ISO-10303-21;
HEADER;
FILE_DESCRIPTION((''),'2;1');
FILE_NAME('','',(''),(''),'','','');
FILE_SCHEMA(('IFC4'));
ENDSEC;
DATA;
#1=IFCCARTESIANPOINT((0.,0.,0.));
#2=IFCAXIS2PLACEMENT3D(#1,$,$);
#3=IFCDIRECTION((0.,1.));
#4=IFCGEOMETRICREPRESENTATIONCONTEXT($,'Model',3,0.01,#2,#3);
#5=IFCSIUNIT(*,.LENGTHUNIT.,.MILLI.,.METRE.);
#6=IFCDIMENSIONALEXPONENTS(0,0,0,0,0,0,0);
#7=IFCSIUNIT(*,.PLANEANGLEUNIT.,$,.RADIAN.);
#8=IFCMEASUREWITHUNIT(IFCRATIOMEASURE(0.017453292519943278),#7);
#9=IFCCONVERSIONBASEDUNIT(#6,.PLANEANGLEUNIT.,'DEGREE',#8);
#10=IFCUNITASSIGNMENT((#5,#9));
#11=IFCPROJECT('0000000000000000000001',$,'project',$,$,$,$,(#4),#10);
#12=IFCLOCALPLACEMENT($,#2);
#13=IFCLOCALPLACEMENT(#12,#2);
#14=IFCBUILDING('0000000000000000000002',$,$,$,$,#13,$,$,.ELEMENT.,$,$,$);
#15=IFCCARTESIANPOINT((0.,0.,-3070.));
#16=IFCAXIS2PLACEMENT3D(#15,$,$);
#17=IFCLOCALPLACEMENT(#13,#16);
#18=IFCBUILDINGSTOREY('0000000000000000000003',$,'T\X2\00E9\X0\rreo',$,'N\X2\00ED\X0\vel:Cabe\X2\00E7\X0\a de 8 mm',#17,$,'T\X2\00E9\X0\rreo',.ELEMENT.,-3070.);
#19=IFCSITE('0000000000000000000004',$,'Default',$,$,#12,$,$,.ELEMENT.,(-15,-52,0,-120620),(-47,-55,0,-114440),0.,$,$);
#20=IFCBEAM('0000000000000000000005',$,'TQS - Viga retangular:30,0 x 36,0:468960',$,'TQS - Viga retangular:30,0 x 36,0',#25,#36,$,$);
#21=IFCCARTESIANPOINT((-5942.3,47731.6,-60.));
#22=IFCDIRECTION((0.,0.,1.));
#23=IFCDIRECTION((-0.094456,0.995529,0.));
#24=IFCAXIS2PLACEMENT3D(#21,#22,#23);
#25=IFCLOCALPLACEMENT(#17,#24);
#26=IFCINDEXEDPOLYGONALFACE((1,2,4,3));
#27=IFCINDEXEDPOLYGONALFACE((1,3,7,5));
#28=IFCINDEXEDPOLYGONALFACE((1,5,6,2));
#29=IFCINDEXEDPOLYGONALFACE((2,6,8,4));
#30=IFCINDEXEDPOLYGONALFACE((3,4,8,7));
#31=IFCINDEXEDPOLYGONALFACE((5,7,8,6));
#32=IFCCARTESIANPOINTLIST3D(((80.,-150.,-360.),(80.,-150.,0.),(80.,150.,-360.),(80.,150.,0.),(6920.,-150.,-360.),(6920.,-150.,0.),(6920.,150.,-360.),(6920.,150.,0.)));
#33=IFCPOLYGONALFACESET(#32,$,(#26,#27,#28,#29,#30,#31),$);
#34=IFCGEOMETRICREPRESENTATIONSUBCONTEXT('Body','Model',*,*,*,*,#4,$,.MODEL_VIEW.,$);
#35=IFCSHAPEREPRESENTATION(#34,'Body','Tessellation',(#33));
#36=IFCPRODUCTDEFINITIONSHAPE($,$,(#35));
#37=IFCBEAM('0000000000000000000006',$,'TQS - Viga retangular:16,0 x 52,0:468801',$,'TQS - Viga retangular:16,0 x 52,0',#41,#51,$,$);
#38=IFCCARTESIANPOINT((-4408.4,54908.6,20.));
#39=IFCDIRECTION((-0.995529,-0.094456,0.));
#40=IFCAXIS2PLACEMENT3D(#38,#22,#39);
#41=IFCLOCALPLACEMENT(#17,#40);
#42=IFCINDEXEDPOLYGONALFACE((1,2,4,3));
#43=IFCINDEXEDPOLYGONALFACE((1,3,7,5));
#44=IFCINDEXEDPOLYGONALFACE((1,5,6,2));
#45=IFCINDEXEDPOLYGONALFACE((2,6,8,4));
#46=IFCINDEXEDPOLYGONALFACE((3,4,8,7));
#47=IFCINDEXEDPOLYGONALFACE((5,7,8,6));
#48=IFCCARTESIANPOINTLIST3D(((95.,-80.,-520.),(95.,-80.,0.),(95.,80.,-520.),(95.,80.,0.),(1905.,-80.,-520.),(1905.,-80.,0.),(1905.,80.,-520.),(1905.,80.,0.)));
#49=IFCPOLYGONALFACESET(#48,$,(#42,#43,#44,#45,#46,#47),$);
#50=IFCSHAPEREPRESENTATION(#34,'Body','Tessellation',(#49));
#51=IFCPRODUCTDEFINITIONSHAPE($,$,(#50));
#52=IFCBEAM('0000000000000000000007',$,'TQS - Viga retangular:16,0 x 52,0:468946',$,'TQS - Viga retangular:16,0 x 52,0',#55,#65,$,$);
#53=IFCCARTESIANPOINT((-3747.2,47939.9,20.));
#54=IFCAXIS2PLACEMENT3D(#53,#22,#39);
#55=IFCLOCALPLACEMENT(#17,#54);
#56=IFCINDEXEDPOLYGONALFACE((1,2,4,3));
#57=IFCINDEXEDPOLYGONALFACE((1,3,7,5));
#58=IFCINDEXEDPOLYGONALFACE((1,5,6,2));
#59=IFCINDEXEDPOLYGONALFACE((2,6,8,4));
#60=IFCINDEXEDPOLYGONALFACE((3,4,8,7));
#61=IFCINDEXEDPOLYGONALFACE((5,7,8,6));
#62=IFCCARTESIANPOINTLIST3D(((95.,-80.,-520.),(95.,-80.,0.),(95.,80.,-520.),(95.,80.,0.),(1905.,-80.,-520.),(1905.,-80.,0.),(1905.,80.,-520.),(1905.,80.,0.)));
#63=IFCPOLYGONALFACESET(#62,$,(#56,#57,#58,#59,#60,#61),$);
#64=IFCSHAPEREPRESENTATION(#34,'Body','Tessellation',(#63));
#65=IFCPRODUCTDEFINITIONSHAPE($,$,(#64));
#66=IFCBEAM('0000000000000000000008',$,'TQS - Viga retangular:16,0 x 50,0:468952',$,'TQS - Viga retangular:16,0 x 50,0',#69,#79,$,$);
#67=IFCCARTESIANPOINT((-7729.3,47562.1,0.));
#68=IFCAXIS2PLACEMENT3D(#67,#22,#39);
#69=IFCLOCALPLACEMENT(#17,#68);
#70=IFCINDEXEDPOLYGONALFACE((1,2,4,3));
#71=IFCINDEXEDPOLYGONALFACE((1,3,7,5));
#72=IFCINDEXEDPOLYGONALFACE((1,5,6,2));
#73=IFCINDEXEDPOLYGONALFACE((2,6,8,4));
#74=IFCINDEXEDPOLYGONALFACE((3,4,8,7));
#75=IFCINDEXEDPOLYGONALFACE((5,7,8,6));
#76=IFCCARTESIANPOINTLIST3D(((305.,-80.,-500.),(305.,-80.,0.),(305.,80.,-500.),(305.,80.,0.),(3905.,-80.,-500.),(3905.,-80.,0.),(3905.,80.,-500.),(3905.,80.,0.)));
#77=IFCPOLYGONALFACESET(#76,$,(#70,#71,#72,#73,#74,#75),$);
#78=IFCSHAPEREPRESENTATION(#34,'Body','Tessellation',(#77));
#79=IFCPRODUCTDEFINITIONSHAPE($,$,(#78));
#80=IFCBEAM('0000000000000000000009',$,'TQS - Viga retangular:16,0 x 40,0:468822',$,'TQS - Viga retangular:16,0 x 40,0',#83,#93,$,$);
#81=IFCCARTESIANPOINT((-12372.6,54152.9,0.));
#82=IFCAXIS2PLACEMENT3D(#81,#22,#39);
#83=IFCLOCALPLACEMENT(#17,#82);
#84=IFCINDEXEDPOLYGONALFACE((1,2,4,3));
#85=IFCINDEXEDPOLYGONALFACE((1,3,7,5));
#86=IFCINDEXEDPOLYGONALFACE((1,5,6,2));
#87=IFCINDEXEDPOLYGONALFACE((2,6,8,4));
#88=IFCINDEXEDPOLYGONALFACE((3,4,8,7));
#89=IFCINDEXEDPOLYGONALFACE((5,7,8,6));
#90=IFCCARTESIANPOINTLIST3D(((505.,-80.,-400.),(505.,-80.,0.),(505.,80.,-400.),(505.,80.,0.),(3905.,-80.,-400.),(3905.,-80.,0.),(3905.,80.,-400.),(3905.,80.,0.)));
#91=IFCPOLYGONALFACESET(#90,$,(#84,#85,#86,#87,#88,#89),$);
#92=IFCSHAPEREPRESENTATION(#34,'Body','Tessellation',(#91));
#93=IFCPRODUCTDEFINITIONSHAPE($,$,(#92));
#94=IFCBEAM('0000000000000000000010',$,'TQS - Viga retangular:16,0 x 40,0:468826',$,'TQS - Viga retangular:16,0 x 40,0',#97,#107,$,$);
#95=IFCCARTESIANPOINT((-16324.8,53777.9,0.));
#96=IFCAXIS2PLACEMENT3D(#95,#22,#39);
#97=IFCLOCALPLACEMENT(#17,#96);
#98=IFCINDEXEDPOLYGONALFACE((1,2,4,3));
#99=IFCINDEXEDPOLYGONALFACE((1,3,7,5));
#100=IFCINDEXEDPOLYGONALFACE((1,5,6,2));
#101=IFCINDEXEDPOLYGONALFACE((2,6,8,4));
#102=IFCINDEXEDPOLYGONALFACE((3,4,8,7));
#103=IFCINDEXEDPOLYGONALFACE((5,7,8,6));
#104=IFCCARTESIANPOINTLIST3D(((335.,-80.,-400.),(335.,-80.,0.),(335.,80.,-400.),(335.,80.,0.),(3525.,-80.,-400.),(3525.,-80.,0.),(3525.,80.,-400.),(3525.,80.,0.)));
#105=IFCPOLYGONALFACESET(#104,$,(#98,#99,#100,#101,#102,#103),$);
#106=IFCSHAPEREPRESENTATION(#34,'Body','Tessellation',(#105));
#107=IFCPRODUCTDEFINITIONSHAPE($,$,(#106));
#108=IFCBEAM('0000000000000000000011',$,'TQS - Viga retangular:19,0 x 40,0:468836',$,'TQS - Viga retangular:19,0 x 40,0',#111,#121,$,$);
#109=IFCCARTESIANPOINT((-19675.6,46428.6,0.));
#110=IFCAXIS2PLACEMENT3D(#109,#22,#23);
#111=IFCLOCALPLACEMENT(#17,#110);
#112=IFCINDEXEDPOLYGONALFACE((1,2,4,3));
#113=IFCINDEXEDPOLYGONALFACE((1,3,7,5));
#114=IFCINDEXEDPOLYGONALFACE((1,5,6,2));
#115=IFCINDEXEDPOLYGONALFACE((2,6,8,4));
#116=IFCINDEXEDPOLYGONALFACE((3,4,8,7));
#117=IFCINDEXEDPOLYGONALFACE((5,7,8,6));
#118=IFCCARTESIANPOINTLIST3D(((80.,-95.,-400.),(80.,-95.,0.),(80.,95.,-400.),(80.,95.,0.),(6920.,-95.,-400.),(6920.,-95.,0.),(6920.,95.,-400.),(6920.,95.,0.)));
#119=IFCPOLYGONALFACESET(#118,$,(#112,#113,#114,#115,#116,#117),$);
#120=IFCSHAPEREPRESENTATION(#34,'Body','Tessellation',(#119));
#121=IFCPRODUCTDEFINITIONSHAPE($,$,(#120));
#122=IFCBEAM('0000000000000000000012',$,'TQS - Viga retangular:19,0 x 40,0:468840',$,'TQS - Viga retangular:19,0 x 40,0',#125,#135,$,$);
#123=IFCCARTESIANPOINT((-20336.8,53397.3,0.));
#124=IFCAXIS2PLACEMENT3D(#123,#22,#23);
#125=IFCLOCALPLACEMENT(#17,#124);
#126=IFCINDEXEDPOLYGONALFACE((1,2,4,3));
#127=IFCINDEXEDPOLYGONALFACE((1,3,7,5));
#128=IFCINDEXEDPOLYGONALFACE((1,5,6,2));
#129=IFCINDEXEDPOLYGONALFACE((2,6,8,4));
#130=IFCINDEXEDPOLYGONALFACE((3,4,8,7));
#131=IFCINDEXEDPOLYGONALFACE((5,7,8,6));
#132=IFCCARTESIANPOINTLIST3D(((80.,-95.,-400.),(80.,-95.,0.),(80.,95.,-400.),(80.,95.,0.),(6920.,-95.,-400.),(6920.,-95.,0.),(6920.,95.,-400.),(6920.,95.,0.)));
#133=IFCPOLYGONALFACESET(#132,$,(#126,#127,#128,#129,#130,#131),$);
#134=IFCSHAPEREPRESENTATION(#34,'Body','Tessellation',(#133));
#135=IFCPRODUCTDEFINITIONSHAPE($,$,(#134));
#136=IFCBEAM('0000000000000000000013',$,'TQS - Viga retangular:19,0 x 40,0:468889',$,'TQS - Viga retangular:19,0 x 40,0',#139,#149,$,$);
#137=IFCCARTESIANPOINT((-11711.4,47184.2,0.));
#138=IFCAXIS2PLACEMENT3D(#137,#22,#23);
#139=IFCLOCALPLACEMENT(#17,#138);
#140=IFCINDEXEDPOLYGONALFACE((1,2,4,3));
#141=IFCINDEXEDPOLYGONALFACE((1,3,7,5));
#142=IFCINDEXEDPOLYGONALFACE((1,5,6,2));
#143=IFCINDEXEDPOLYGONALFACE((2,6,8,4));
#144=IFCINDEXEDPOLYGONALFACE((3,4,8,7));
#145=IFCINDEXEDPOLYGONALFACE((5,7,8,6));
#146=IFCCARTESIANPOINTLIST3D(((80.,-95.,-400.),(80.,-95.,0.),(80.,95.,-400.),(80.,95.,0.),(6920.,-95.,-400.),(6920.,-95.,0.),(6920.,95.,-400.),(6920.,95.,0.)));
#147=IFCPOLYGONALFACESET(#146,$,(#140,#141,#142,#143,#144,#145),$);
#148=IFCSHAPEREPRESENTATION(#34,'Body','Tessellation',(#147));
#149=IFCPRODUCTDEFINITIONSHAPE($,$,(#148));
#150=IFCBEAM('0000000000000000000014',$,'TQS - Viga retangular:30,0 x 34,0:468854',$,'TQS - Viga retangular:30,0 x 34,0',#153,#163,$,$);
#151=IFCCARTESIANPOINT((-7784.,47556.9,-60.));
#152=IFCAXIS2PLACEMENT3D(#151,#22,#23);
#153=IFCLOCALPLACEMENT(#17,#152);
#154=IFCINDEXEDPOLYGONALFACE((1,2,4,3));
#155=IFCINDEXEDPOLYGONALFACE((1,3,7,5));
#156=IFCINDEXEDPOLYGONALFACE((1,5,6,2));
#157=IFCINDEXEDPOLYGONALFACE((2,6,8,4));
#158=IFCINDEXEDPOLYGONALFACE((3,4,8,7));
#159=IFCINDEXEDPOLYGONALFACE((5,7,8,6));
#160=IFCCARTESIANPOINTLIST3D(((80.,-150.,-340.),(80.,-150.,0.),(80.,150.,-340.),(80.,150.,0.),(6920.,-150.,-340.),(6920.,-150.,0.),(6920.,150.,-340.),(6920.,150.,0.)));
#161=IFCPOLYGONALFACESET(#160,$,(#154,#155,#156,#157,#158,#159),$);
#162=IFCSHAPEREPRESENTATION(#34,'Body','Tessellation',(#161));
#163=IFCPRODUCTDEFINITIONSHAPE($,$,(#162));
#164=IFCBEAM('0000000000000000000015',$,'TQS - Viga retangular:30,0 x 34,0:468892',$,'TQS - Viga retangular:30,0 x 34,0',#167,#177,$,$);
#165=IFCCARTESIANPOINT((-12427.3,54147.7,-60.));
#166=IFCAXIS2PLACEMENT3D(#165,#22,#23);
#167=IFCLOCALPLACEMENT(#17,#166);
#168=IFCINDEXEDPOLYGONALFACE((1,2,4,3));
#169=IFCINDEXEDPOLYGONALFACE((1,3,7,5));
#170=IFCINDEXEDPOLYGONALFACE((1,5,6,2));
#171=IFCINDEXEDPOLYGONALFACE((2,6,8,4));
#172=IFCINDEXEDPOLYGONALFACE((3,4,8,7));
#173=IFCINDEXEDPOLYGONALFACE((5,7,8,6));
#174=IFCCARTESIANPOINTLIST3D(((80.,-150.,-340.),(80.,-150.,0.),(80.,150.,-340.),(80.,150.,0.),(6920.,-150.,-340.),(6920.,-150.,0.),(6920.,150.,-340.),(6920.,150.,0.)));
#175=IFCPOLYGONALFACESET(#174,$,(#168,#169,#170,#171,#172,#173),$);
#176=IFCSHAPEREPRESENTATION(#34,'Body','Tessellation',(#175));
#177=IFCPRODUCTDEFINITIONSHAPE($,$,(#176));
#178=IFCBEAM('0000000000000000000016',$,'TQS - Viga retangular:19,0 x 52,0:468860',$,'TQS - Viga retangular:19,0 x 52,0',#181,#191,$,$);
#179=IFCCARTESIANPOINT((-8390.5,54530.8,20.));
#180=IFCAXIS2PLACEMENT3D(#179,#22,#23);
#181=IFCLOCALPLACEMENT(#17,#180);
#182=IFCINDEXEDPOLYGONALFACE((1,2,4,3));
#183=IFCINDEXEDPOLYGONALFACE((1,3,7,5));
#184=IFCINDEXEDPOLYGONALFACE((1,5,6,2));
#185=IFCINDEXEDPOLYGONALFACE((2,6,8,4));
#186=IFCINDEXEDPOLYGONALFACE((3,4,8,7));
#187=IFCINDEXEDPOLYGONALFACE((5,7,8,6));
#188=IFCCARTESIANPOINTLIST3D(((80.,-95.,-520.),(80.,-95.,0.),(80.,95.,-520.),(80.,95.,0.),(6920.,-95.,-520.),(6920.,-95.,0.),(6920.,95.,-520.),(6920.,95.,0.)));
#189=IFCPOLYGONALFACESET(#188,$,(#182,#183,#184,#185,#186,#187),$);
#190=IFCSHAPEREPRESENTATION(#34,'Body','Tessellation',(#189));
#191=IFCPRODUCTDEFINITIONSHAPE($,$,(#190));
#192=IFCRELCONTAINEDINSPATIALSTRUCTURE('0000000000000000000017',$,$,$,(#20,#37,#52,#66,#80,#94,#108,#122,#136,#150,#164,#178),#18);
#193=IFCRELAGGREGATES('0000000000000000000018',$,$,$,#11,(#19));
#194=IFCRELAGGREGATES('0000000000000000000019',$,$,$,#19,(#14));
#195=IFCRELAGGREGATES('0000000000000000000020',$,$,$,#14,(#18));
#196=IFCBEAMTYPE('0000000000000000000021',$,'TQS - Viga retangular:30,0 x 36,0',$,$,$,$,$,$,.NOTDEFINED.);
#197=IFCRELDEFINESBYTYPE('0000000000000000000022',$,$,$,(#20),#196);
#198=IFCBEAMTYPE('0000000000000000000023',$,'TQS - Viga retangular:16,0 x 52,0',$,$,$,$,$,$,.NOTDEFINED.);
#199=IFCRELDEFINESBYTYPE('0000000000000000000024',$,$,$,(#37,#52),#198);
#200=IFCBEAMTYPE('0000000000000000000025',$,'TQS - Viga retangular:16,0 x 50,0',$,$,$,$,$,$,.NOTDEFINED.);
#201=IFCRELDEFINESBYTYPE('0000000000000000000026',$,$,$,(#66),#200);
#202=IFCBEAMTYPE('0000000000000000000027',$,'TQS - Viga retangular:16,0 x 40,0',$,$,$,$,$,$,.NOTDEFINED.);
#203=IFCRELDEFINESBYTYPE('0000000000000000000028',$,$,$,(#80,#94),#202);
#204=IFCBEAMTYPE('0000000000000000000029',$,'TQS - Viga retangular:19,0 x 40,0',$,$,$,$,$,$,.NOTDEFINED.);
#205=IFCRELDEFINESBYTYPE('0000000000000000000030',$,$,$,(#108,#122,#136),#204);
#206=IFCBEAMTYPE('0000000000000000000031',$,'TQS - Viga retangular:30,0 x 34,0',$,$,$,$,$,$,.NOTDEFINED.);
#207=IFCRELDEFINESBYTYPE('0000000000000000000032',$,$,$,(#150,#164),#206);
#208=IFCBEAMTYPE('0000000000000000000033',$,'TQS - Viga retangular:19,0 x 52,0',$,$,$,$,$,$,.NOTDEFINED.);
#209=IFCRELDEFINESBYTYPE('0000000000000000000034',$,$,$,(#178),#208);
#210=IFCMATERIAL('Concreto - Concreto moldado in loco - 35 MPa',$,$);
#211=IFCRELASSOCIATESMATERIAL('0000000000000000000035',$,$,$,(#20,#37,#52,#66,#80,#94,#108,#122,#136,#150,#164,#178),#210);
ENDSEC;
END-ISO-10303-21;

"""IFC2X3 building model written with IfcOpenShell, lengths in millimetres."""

from ifc_helpers import new_model, entity, si_unit, converted_unit, direction, frame, frame_2d, origin, origin_2d_with_axis, place, context, subcontext, project, spatial, rectangle, extrude, material, type_object, element, save


model = new_model("IFC2X3")

# Units and contexts
model_context = context("Model", 3, precision=0.01, world=origin(), true_north=direction((0.0, 1.0)))
body_context = subcontext(model_context, "Body", "Model", "MODEL_VIEW")
ifc_project = project(units=[si_unit("LENGTHUNIT", "METRE", prefix="MILLI"), converted_unit("PLANEANGLEUNIT", "DEGREE", entity("IfcRatioMeasure", 0.017453292519943278), si_unit("PLANEANGLEUNIT", "RADIAN"), dimensions=[0, 0, 0, 0, 0, 0, 0])], contexts=[model_context])

# Site, building, storey
site_placement = place(None, origin())
site = spatial("IfcSite", under=ifc_project, at=site_placement, Name="Default", CompositionType="ELEMENT", RefLatitude=(-15, -52, 0, -120620), RefLongitude=(-47, -55, 0, -114440), RefElevation=0.0)
building_placement = place(site_placement, origin())
building = spatial("IfcBuilding", under=site, at=building_placement, CompositionType="ELEMENT")
storey_placement = place(building_placement, frame((0.0, 0.0, -3070.0)))
storey = spatial("IfcBuildingStorey", under=building, at=storey_placement, Name="Térreo", ObjectType="Nível:Cabeça de 8 mm", LongName="Térreo", CompositionType="ELEMENT", Elevation=-3070.0)

# Beams
ifc_material_1 = material(Name="Concreto - Concreto moldado in loco - 35 MPa")
beam_type_1 = type_object("IfcBeamType", Name="TQS - Viga retangular:30,0 x 36,0", PredefinedType="NOTDEFINED")
beam_1_placement = place(storey_placement, frame((-5942.3, 47731.6, -60.0), z_axis=(0.0, 0.0, 1.0), x_axis=(-0.094456, 0.995529, 0.0)))
element("IfcBeam", 1, at=beam_1_placement, inside=storey, type_object=beam_type_1, material=ifc_material_1, Name="TQS - Viga retangular:30,0 x 36,0:468960", ObjectType="TQS - Viga retangular:30,0 x 36,0", context=body_context, shape_type="SweptSolid", body=[
    extrude(rectangle(XDim=360.0, YDim=300.0, at=frame_2d((0.0, 0.0), x_axis=(1.0, 0.0))), frame((80.0, 0.0, -180.0), z_axis=(1.0, 0.0, 0.0), x_axis=(0.0, 0.0, -1.0)), (0.0, 0.0, 1.0), 6840.0),
])
beam_type_2 = type_object("IfcBeamType", Name="TQS - Viga retangular:16,0 x 52,0", PredefinedType="NOTDEFINED")
beam_2_placement = place(storey_placement, frame((-4408.4, 54908.6, 20.0), z_axis=(0.0, 0.0, 1.0), x_axis=(-0.995529, -0.094456, 0.0)))
element("IfcBeam", 2, at=beam_2_placement, inside=storey, type_object=beam_type_2, material=ifc_material_1, Name="TQS - Viga retangular:16,0 x 52,0:468801", ObjectType="TQS - Viga retangular:16,0 x 52,0", context=body_context, shape_type="SweptSolid", body=[
    extrude(rectangle(XDim=520.0, YDim=160.0, at=frame_2d((0.0, 0.0), x_axis=(1.0, 0.0))), frame((95.0, 0.0, -260.0), z_axis=(1.0, 0.0, 0.0), x_axis=(0.0, 0.0, -1.0)), (0.0, 0.0, 1.0), 1810.0),
])
beam_3_placement = place(storey_placement, frame((-3747.2, 47939.9, 20.0), z_axis=(0.0, 0.0, 1.0), x_axis=(-0.995529, -0.094456, 0.0)))
element("IfcBeam", 3, at=beam_3_placement, inside=storey, type_object=beam_type_2, material=ifc_material_1, Name="TQS - Viga retangular:16,0 x 52,0:468946", ObjectType="TQS - Viga retangular:16,0 x 52,0", context=body_context, shape_type="SweptSolid", body=[
    extrude(rectangle(XDim=520.0, YDim=160.0, at=frame_2d((0.0, 0.0), x_axis=(1.0, 0.0))), frame((95.0, 0.0, -260.0), z_axis=(1.0, 0.0, 0.0), x_axis=(0.0, 0.0, -1.0)), (0.0, 0.0, 1.0), 1810.0),
])
beam_type_3 = type_object("IfcBeamType", Name="TQS - Viga retangular:16,0 x 50,0", PredefinedType="NOTDEFINED")
beam_4_placement = place(storey_placement, frame((-7729.3, 47562.1, 0.0), z_axis=(0.0, 0.0, 1.0), x_axis=(-0.995529, -0.094456, 0.0)))
element("IfcBeam", 4, at=beam_4_placement, inside=storey, type_object=beam_type_3, material=ifc_material_1, Name="TQS - Viga retangular:16,0 x 50,0:468952", ObjectType="TQS - Viga retangular:16,0 x 50,0", context=body_context, shape_type="SweptSolid", body=[
    extrude(rectangle(XDim=500.0, YDim=160.0, at=frame_2d((0.0, 0.0), x_axis=(1.0, 0.0))), frame((305.0, 0.0, -250.0), z_axis=(1.0, 0.0, 0.0), x_axis=(0.0, 0.0, -1.0)), (0.0, 0.0, 1.0), 3600.0),
])
beam_type_4 = type_object("IfcBeamType", Name="TQS - Viga retangular:16,0 x 40,0", PredefinedType="NOTDEFINED")
beam_5_placement = place(storey_placement, frame((-12372.6, 54152.9, 0.0), z_axis=(0.0, 0.0, 1.0), x_axis=(-0.995529, -0.094456, 0.0)))
element("IfcBeam", 5, at=beam_5_placement, inside=storey, type_object=beam_type_4, material=ifc_material_1, Name="TQS - Viga retangular:16,0 x 40,0:468822", ObjectType="TQS - Viga retangular:16,0 x 40,0", context=body_context, shape_type="SweptSolid", body=[
    extrude(rectangle(XDim=400.0, YDim=160.0, at=frame_2d((0.0, 0.0), x_axis=(1.0, 0.0))), frame((505.0, 0.0, -200.0), z_axis=(1.0, 0.0, 0.0), x_axis=(0.0, 0.0, -1.0)), (0.0, 0.0, 1.0), 3400.0),
])
beam_6_placement = place(storey_placement, frame((-16324.8, 53777.9, 0.0), z_axis=(0.0, 0.0, 1.0), x_axis=(-0.995529, -0.094456, 0.0)))
element("IfcBeam", 6, at=beam_6_placement, inside=storey, type_object=beam_type_4, material=ifc_material_1, Name="TQS - Viga retangular:16,0 x 40,0:468826", ObjectType="TQS - Viga retangular:16,0 x 40,0", context=body_context, shape_type="SweptSolid", body=[
    extrude(rectangle(XDim=400.0, YDim=160.0, at=frame_2d((0.0, 0.0), x_axis=(1.0, 0.0))), frame((335.0, 0.0, -200.0), z_axis=(1.0, 0.0, 0.0), x_axis=(0.0, 0.0, -1.0)), (0.0, 0.0, 1.0), 3190.0),
])
beam_type_5 = type_object("IfcBeamType", Name="TQS - Viga retangular:19,0 x 40,0", PredefinedType="NOTDEFINED")
beam_7_placement = place(storey_placement, frame((-19675.6, 46428.6, 0.0), z_axis=(0.0, 0.0, 1.0), x_axis=(-0.094456, 0.995529, 0.0)))
element("IfcBeam", 7, at=beam_7_placement, inside=storey, type_object=beam_type_5, material=ifc_material_1, Name="TQS - Viga retangular:19,0 x 40,0:468836", ObjectType="TQS - Viga retangular:19,0 x 40,0", context=body_context, shape_type="SweptSolid", body=[
    extrude(rectangle(XDim=400.0, YDim=190.0, at=origin_2d_with_axis()), frame((80.0, 0.0, -200.0), z_axis=(1.0, 0.0, 0.0), x_axis=(0.0, 0.0, -1.0)), (0.0, 0.0, 1.0), 6840.0),
])
beam_8_placement = place(storey_placement, frame((-20336.8, 53397.3, 0.0), z_axis=(0.0, 0.0, 1.0), x_axis=(-0.094456, 0.995529, 0.0)))
element("IfcBeam", 8, at=beam_8_placement, inside=storey, type_object=beam_type_5, material=ifc_material_1, Name="TQS - Viga retangular:19,0 x 40,0:468840", ObjectType="TQS - Viga retangular:19,0 x 40,0", context=body_context, shape_type="SweptSolid", body=[
    extrude(rectangle(XDim=400.0, YDim=190.0, at=frame_2d((0.0, 0.0), x_axis=(1.0, 0.0))), frame((80.0, 0.0, -200.0), z_axis=(1.0, 0.0, 0.0), x_axis=(0.0, 0.0, -1.0)), (0.0, 0.0, 1.0), 6840.0),
])
beam_9_placement = place(storey_placement, frame((-11711.4, 47184.2, 0.0), z_axis=(0.0, 0.0, 1.0), x_axis=(-0.094456, 0.995529, 0.0)))
element("IfcBeam", 9, at=beam_9_placement, inside=storey, type_object=beam_type_5, material=ifc_material_1, Name="TQS - Viga retangular:19,0 x 40,0:468889", ObjectType="TQS - Viga retangular:19,0 x 40,0", context=body_context, shape_type="SweptSolid", body=[
    extrude(rectangle(XDim=400.0, YDim=190.0, at=frame_2d((0.0, 0.0), x_axis=(1.0, 0.0))), frame((80.0, 0.0, -200.0), z_axis=(1.0, 0.0, 0.0), x_axis=(0.0, 0.0, -1.0)), (0.0, 0.0, 1.0), 6840.0),
])
beam_type_6 = type_object("IfcBeamType", Name="TQS - Viga retangular:30,0 x 34,0", PredefinedType="NOTDEFINED")
beam_10_placement = place(storey_placement, frame((-7784.0, 47556.9, -60.0), z_axis=(0.0, 0.0, 1.0), x_axis=(-0.094456, 0.995529, 0.0)))
element("IfcBeam", 10, at=beam_10_placement, inside=storey, type_object=beam_type_6, material=ifc_material_1, Name="TQS - Viga retangular:30,0 x 34,0:468854", ObjectType="TQS - Viga retangular:30,0 x 34,0", context=body_context, shape_type="SweptSolid", body=[
    extrude(rectangle(XDim=340.0, YDim=300.0, at=frame_2d((0.0, 0.0), x_axis=(1.0, 0.0))), frame((80.0, 0.0, -170.0), z_axis=(1.0, 0.0, 0.0), x_axis=(0.0, 0.0, -1.0)), (0.0, 0.0, 1.0), 6840.0),
])
beam_11_placement = place(storey_placement, frame((-12427.3, 54147.7, -60.0), z_axis=(0.0, 0.0, 1.0), x_axis=(-0.094456, 0.995529, 0.0)))
element("IfcBeam", 11, at=beam_11_placement, inside=storey, type_object=beam_type_6, material=ifc_material_1, Name="TQS - Viga retangular:30,0 x 34,0:468892", ObjectType="TQS - Viga retangular:30,0 x 34,0", context=body_context, shape_type="SweptSolid", body=[
    extrude(rectangle(XDim=340.0, YDim=300.0, at=frame_2d((0.0, 0.0), x_axis=(1.0, 0.0))), frame((80.0, 0.0, -170.0), z_axis=(1.0, 0.0, 0.0), x_axis=(0.0, 0.0, -1.0)), (0.0, 0.0, 1.0), 6840.0),
])
beam_type_7 = type_object("IfcBeamType", Name="TQS - Viga retangular:19,0 x 52,0", PredefinedType="NOTDEFINED")
beam_12_placement = place(storey_placement, frame((-8390.5, 54530.8, 20.0), z_axis=(0.0, 0.0, 1.0), x_axis=(-0.094456, 0.995529, 0.0)))
element("IfcBeam", 12, at=beam_12_placement, inside=storey, type_object=beam_type_7, material=ifc_material_1, Name="TQS - Viga retangular:19,0 x 52,0:468860", ObjectType="TQS - Viga retangular:19,0 x 52,0", context=body_context, shape_type="SweptSolid", body=[
    extrude(rectangle(XDim=520.0, YDim=190.0, at=frame_2d((0.0, 0.0), x_axis=(1.0, 0.0))), frame((80.0, 0.0, -260.0), z_axis=(1.0, 0.0, 0.0), x_axis=(0.0, 0.0, -1.0)), (0.0, 0.0, 1.0), 6840.0),
])

save(model, "model.ifc")
